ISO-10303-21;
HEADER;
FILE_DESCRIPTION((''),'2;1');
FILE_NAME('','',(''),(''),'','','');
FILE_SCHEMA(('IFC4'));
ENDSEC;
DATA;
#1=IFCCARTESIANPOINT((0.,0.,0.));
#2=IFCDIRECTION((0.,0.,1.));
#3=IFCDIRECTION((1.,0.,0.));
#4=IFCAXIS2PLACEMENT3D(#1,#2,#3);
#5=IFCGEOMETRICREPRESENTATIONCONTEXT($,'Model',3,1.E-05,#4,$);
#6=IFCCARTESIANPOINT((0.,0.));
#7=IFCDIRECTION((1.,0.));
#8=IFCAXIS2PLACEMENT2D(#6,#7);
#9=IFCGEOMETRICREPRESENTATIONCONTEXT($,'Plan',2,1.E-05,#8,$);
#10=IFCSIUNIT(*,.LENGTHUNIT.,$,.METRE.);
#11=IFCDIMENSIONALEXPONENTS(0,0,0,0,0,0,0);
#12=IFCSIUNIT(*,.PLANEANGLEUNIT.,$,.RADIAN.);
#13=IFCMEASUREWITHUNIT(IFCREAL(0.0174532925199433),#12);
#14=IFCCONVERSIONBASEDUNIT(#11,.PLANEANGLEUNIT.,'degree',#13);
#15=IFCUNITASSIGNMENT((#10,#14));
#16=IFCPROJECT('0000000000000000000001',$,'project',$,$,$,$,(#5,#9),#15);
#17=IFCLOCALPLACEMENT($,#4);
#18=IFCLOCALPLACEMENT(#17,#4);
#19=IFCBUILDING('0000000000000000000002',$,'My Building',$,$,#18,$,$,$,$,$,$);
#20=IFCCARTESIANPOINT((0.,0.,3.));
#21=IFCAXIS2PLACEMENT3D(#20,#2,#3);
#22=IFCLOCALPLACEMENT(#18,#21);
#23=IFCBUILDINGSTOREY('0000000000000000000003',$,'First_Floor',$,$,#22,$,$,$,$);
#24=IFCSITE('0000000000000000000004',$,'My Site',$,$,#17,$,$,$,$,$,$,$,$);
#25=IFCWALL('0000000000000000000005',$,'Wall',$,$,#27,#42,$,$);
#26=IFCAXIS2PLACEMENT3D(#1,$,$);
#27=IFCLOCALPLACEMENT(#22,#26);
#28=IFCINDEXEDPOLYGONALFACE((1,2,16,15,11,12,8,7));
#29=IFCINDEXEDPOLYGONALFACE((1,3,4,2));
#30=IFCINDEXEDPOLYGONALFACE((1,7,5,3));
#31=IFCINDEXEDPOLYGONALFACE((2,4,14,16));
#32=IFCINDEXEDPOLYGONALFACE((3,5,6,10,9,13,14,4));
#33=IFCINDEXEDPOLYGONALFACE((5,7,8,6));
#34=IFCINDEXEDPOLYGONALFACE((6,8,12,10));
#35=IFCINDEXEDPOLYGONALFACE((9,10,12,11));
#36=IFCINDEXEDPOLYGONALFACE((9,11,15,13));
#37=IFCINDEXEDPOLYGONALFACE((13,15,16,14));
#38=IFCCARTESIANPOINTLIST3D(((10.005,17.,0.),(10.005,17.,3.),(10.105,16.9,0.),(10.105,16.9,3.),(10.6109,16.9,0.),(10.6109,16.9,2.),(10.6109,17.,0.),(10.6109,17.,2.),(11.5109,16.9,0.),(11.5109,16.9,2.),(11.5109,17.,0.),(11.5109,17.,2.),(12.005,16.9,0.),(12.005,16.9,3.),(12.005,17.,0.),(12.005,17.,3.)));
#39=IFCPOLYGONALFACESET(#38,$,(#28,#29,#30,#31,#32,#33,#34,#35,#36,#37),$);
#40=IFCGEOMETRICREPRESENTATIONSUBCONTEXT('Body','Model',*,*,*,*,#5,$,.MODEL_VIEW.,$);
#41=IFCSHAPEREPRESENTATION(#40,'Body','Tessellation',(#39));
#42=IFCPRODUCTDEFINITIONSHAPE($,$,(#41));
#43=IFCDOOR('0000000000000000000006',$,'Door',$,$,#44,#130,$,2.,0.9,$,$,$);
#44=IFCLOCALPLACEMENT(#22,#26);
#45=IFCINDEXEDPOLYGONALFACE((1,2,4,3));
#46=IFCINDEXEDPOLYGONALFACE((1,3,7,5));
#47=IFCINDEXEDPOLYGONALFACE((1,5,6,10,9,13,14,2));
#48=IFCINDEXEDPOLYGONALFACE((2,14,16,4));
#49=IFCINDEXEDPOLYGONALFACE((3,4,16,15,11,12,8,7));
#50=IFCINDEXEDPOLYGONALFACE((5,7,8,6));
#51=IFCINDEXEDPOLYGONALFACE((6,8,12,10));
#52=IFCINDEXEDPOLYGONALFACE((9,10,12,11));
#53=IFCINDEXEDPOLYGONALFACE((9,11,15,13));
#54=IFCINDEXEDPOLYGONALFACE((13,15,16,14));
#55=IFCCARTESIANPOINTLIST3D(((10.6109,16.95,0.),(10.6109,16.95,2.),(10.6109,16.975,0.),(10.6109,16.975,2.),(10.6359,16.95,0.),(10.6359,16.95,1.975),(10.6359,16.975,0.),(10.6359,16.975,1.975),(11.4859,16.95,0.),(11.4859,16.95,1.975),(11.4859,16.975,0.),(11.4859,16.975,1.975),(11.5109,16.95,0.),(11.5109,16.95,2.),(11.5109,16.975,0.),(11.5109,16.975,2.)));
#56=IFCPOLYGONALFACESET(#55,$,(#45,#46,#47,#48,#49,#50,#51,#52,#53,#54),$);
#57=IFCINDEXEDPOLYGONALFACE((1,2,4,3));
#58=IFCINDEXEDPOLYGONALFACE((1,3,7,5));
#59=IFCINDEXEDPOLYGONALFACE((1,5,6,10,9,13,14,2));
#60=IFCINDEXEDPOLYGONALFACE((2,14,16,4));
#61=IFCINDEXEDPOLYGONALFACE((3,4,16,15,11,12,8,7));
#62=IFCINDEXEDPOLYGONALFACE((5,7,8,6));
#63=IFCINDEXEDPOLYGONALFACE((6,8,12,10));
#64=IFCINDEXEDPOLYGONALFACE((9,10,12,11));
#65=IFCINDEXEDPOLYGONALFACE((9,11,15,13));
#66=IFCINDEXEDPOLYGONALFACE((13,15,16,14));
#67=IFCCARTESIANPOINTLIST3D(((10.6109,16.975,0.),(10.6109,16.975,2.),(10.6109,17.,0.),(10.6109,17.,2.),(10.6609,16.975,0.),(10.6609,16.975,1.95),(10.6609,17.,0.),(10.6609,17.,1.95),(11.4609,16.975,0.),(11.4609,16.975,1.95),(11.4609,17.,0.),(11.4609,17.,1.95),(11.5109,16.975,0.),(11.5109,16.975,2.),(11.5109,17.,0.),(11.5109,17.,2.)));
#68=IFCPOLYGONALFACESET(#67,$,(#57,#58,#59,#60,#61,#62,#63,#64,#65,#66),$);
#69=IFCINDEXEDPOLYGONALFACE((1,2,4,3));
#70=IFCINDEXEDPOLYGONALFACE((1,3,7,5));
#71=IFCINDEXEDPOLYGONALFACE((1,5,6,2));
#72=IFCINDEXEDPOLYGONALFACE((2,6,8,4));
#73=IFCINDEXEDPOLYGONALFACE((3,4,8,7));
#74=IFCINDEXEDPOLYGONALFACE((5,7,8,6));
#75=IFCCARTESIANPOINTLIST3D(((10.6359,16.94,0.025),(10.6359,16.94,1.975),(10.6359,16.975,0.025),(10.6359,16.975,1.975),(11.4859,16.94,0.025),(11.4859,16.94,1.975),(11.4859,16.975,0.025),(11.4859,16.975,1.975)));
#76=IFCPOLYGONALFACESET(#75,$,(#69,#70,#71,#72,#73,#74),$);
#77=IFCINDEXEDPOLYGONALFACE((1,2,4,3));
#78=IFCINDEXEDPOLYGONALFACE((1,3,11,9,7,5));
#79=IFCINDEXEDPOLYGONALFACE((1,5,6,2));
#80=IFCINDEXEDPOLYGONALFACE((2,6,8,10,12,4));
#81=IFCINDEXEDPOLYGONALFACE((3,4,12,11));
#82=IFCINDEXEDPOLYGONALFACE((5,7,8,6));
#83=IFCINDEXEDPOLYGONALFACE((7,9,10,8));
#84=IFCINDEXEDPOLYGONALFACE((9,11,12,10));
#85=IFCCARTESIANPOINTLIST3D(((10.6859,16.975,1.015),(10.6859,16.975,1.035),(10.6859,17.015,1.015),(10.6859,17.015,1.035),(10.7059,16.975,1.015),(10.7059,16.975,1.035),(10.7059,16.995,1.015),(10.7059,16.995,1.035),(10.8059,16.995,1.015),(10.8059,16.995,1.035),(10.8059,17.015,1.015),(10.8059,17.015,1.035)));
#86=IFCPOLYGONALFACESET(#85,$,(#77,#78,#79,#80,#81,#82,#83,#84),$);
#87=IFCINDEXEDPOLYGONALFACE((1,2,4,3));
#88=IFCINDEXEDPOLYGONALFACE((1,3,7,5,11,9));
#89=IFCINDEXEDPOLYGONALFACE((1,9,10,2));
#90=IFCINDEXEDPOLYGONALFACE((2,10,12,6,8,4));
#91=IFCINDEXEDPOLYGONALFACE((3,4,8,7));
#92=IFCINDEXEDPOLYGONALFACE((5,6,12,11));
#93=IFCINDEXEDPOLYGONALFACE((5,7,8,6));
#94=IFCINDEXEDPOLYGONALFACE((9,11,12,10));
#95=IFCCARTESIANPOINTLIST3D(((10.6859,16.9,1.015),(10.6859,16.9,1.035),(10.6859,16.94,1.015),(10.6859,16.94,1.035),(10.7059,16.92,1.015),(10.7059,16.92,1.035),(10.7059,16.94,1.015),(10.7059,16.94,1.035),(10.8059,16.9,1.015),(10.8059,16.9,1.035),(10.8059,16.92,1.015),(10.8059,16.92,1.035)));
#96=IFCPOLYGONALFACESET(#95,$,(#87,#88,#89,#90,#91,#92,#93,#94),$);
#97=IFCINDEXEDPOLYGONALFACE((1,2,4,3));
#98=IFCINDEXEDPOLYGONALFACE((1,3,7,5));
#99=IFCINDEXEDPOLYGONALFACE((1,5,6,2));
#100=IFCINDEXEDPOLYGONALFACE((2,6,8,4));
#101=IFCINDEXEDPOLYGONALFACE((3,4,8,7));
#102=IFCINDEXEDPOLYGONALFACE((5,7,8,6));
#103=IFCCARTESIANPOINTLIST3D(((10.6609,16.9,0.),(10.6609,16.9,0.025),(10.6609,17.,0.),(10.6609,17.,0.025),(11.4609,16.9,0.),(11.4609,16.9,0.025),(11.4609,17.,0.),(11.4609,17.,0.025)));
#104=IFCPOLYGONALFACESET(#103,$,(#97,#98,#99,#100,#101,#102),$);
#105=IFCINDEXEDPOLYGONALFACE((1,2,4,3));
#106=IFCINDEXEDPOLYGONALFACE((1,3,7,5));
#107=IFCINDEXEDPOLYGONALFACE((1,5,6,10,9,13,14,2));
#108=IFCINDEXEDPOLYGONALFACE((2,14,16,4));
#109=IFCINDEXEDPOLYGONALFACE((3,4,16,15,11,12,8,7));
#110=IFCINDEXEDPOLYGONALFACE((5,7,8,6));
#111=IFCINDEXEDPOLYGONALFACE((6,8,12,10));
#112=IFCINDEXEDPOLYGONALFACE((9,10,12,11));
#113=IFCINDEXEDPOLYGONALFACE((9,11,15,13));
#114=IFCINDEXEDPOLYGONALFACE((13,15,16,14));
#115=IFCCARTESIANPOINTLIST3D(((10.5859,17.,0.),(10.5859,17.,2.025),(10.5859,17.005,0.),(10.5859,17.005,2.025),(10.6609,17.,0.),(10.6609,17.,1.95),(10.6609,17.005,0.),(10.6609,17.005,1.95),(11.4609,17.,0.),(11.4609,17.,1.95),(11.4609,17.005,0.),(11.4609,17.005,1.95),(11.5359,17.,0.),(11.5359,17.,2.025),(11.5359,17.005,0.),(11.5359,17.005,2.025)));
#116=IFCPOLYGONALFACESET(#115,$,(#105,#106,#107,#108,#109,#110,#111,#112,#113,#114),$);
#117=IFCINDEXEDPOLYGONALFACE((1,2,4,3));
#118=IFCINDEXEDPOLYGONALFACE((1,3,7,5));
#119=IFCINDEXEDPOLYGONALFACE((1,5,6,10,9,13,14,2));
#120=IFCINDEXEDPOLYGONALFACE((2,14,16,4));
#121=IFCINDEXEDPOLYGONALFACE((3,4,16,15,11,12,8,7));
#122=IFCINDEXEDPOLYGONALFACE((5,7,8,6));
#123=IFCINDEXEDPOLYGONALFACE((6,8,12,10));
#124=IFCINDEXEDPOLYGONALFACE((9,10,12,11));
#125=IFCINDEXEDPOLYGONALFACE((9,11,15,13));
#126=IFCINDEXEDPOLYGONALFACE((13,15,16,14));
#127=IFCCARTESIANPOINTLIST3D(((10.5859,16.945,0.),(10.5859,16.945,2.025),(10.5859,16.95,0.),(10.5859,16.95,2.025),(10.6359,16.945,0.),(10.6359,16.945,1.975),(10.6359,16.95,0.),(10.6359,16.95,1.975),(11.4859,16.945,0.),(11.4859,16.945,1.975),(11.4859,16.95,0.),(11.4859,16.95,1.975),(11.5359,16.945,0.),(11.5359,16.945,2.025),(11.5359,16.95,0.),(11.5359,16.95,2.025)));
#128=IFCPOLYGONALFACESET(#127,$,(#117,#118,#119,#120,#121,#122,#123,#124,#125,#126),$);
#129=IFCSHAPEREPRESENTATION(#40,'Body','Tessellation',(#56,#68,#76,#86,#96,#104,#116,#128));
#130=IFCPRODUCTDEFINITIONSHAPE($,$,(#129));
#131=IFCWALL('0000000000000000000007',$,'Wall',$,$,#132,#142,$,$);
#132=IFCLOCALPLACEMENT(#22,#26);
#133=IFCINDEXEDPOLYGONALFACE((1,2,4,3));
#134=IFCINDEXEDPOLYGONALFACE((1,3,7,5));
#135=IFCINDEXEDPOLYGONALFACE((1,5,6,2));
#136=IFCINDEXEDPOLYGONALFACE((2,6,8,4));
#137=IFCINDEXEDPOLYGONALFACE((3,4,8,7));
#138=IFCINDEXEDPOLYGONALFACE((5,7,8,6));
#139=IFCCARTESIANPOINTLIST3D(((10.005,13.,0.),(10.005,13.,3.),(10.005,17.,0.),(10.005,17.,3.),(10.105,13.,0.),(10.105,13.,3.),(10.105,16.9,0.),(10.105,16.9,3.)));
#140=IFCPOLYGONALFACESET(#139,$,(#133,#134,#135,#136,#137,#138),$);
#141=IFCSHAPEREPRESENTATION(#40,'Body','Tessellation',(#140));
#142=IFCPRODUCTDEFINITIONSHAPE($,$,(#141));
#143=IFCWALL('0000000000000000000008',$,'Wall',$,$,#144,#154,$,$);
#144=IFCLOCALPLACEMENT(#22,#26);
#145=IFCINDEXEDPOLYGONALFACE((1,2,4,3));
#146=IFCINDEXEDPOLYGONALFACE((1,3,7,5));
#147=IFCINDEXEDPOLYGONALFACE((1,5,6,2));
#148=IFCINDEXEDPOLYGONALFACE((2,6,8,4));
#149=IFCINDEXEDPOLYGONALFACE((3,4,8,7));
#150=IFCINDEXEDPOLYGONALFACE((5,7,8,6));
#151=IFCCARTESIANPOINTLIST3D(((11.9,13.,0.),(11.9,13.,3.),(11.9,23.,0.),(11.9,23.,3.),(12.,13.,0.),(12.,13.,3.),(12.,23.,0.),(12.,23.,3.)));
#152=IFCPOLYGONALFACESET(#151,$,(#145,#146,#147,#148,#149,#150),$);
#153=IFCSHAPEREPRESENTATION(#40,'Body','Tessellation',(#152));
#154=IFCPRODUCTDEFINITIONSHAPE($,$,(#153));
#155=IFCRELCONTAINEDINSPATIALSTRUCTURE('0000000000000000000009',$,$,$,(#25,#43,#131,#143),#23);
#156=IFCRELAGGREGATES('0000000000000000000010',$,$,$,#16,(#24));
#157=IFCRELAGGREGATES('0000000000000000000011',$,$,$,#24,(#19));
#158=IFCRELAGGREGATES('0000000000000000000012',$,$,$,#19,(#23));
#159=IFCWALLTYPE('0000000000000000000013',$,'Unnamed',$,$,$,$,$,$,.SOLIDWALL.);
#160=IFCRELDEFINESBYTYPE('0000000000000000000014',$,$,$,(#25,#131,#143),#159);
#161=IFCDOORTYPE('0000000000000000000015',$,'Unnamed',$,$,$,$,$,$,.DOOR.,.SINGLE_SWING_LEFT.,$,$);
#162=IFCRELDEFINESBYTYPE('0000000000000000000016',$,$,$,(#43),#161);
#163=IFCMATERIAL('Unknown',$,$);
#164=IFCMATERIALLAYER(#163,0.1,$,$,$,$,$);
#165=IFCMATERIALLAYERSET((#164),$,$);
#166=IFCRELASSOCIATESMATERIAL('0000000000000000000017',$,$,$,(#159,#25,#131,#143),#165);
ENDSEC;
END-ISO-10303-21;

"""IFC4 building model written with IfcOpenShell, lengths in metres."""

from ifc_helpers import new_model, entity, si_unit, converted_unit, frame, origin_with_axes, origin_2d_with_axis, place, context, subcontext, project, spatial, line, indexed_curve, outline, extrude, shape, source, transform, mapped, material, layer, layer_set, layer_usage, type_object, type_shapes, element, fill, save


model = new_model("IFC4")

# Units and contexts
model_context = context("Model", 3, precision=1e-05, world=origin_with_axes())
plan_context = context("Plan", 2, precision=1e-05, world=origin_2d_with_axis())
body_context_1 = subcontext(model_context, "Body", "Model", "MODEL_VIEW")
body_context_2 = subcontext(plan_context, "Body", "Plan", "PLAN_VIEW")
ifc_project = project(units=[si_unit("LENGTHUNIT", "METRE"), converted_unit("PLANEANGLEUNIT", "degree", entity("IfcReal", 0.0174532925199433), si_unit("PLANEANGLEUNIT", "RADIAN"), dimensions=[0, 0, 0, 0, 0, 0, 0])], contexts=[model_context, plan_context])

# Site, building, storey
site_placement = place(None, origin_with_axes())
site = spatial("IfcSite", under=ifc_project, at=site_placement, Name="My Site")
building_placement = place(site_placement, origin_with_axes())
building = spatial("IfcBuilding", under=site, at=building_placement, Name="My Building")
storey_placement = place(building_placement, frame((0.0, 0.0, 3.0), z_axis=(0.0, 0.0, 1.0), x_axis=(1.0, 0.0, 0.0)))
storey = spatial("IfcBuildingStorey", under=building, at=storey_placement, Name="First_Floor")

# Wall, opening, door
ifc_material = material(Name="Unknown")
ifc_layer = layer(ifc_material, 0.1)
ifc_layer_set = layer_set([ifc_layer])
ifc_layer_usage_1 = layer_usage(ifc_layer_set, "AXIS2", "POSITIVE", 0.0)
wall_type = type_object("IfcWallType", Name="Unnamed", PredefinedType="SOLIDWALL", material=ifc_layer_set)
wall_1_placement = place(storey_placement, frame((12.005, 17.0, 0.0), z_axis=(0.0, 0.0, 1.0), x_axis=(-1.0, 0.0, 0.0)))
wall_1 = element("IfcWall", 1, at=wall_1_placement, inside=storey, type_object=wall_type, material=ifc_layer_usage_1, Name="Wall", context=body_context_1, shape_type="SweptSolid", body=[
    extrude(outline(indexed_curve([(0.0, 0.0), (0.0, 0.1), (1.9, 0.1), (2.0, 0.0)], segments=[line(1, 2, 3, 4, 1)])), origin_with_axes(), (0.0, 0.0, 1.0), 3.0),
])
shared_shape_1 = source(origin_with_axes(), body_context_1, "Body", "SweptSolid", [
    extrude(outline(indexed_curve([(0.0, 0.0), (0.9, 0.0), (0.9, 2.0), (0.0, 2.0)], segments=[line(1, 2, 3, 4, 1)])), frame((0.0, -0.6, 0.0), z_axis=(0.0, -1.0, 0.0), x_axis=(1.0, 0.0, 0.0)), (0.0, 0.0, -1.0), 1.2),
])
opening_1_placement = place(wall_1_placement, frame((0.4941, 0.0, 0.0), z_axis=(0.0, 0.0, 1.0), x_axis=(1.0, 0.0, 0.0)))
opening_1 = element("IfcOpeningElement", 2, at=opening_1_placement, cuts=wall_1, PredefinedType="OPENING", context=body_context_1, shape_type="MappedRepresentation", body=[
    mapped(shared_shape_1, transform((0.0, 0.0, 0.0), x_axis=(1.0, 0.0, 0.0), y_axis=(0.0, 1.0, 0.0), z_axis=(0.0, 0.0, 1.0), scale=1.0)),
])
door_type = type_object("IfcDoorType", Name="Unnamed", OperationType="SINGLE_SWING_LEFT", PredefinedType="DOOR")
shared_shape_2 = source(origin_with_axes(), body_context_1, "Body", "SweptSolid", [
    extrude(outline(indexed_curve([(0.0, 0.0), (0.0, 2.0), (0.9, 2.0), (0.9, 0.0), (0.875, 0.0), (0.875, 1.975), (0.025, 1.975), (0.025, 0.0)], segments=[line(1, 2, 3, 4, 5, 6, 7, 8, 1)])), frame((0.0, 0.025, 0.0), z_axis=(0.0, -1.0, 0.0), x_axis=(1.0, 0.0, 0.0)), (0.0, 0.0, -1.0), 0.025),
    extrude(outline(indexed_curve([(0.0, 0.0), (0.0, 2.0), (0.9, 2.0), (0.9, 0.0), (0.85, 0.0), (0.85, 1.95), (0.05, 1.95), (0.05, 0.0)], segments=[line(1, 2, 3, 4, 5, 6, 7, 8, 1)])), frame((0.0, 0.0, 0.0), z_axis=(0.0, -1.0, 0.0), x_axis=(1.0, 0.0, 0.0)), (0.0, 0.0, -1.0), 0.025),
    extrude(outline(indexed_curve([(0.0, 0.0), (0.85, 0.0), (0.85, 0.035), (0.0, 0.035)], segments=[line(1, 2, 3, 4, 1)])), frame((0.025, 0.025, 0.025), z_axis=(0.0, 0.0, 1.0), x_axis=(1.0, 0.0, 0.0)), (0.0, 0.0, 1.0), 1.95),
    extrude(outline(indexed_curve([(0.0, 0.0), (0.0, -0.04), (-0.12, -0.04), (-0.12, -0.02), (-0.02, -0.02), (-0.02, 0.0)], segments=[line(1, 2, 3, 4, 5, 6, 1)])), frame((0.825, 0.025, 1.015), z_axis=(0.0, 0.0, 1.0), x_axis=(1.0, 0.0, 0.0)), (0.0, 0.0, 1.0), 0.02),
    extrude(outline(indexed_curve([(0.0, 0.0), (0.0, 0.04), (-0.12, 0.04), (-0.12, 0.02), (-0.02, 0.02), (-0.02, 0.0)], segments=[line(1, 2, 3, 4, 5, 6, 1)])), frame((0.825, 0.06, 1.015), z_axis=(0.0, 0.0, 1.0), x_axis=(1.0, 0.0, 0.0)), (0.0, 0.0, 1.0), 0.02),
    extrude(outline(indexed_curve([(0.0, 0.0), (0.8, 0.0), (0.8, 0.1), (0.0, 0.1)], segments=[line(1, 2, 3, 4, 1)])), frame((0.05, 0.0, 0.0), z_axis=(0.0, 0.0, 1.0), x_axis=(1.0, 0.0, 0.0)), (0.0, 0.0, 1.0), 0.025),
    extrude(outline(indexed_curve([(0.0, 0.0), (0.0, 2.025), (0.95, 2.025), (0.95, 0.0), (0.875, 0.0), (0.875, 1.95), (0.075, 1.95), (0.075, 0.0)], segments=[line(1, 2, 3, 4, 5, 6, 7, 8, 1)])), frame((-0.025, -0.005, 0.0), z_axis=(0.0, -1.0, 0.0), x_axis=(1.0, 0.0, 0.0)), (0.0, 0.0, -1.0), 0.005),
    extrude(outline(indexed_curve([(0.0, 0.0), (0.0, 2.025), (0.95, 2.025), (0.95, 0.0), (0.9, 0.0), (0.9, 1.975), (0.05, 1.975), (0.05, 0.0)], segments=[line(1, 2, 3, 4, 5, 6, 7, 8, 1)])), frame((-0.025, 0.05, 0.0), z_axis=(0.0, -1.0, 0.0), x_axis=(1.0, 0.0, 0.0)), (0.0, 0.0, -1.0), 0.005),
])
shared_shape_3 = source(origin_with_axes(), body_context_2, "Body", "Curve2D", [
    entity("IfcIndexedPolyCurve", entity("IfcCartesianPointList2D", [[0.0, 0.0], [0.0, 0.05], [0.025, 0.05], [0.025, 0.025], [0.05, 0.025], [0.05, 0.0]]), [entity("IfcLineIndex", [1, 2, 3, 4, 5, 6, 1])]),
    entity("IfcIndexedPolyCurve", entity("IfcCartesianPointList2D", [[0.9, 0.0], [0.9, 0.05], [0.875, 0.05], [0.875, 0.025], [0.85, 0.025], [0.85, 0.0]]), [entity("IfcLineIndex", [1, 2, 3, 4, 5, 6, 1])]),
    entity("IfcTrimmedCurve", entity("IfcEllipse", entity("IfcAxis2Placement2D", entity("IfcCartesianPoint", [0.06, 0.05]), entity("IfcDirection", [1.0, 0.0])), 0.815, 0.85), [entity("IfcCartesianPoint", [0.875, 0.05])], [entity("IfcCartesianPoint", [0.06, 0.9])], True, "CARTESIAN"),
    entity("IfcIndexedPolyCurve", entity("IfcCartesianPointList2D", [[0.025, 0.05], [0.06, 0.05], [0.06, 0.9], [0.025, 0.9]]), [entity("IfcLineIndex", [1, 2, 3, 4, 1])]),
])
type_shapes(door_type, [shared_shape_2, shared_shape_3])
door_1_placement = place(opening_1_placement, frame((0.0, 0.0, 0.0), z_axis=(0.0, 0.0, 1.0), x_axis=(1.0, 0.0, 0.0)))
door_1 = element("IfcDoor", 3, at=door_1_placement, inside=storey, type_object=door_type, Name="Door", OverallHeight=2.0, OverallWidth=0.9, shapes=[
    shape(body_context_1, "Body", "MappedRepresentation", [mapped(shared_shape_2, transform((0.0, 0.0, 0.0), x_axis=(1.0, 0.0, 0.0), y_axis=(0.0, 1.0, 0.0), z_axis=(0.0, 0.0, 1.0), scale=1.0))]),
    shape(body_context_2, "Body", "MappedRepresentation", [mapped(shared_shape_3, transform((0.0, 0.0, 0.0), x_axis=(1.0, 0.0, 0.0), y_axis=(0.0, 1.0, 0.0), z_axis=(0.0, 0.0, 1.0), scale=1.0))]),
])
fill(opening_1, door_1)

# Walls
ifc_layer_usage_2 = layer_usage(ifc_layer_set, "AXIS2", "POSITIVE", 0.0)
wall_2_placement = place(storey_placement, frame((10.005, 17.0, 0.0), z_axis=(0.0, 0.0, 1.0), x_axis=(0.0, -1.0, 0.0)))
element("IfcWall", 4, at=wall_2_placement, inside=storey, type_object=wall_type, material=ifc_layer_usage_2, Name="Wall", context=body_context_1, shape_type="SweptSolid", body=[
    extrude(outline(indexed_curve([(0.0, 0.0), (0.1, 0.1), (4.0, 0.1), (4.0, 0.0)], segments=[line(1, 2, 3, 4, 1)])), origin_with_axes(), (0.0, 0.0, 1.0), 3.0),
])
ifc_layer_usage_3 = layer_usage(ifc_layer_set, "AXIS2", "POSITIVE", 0.0)
wall_3_placement = place(storey_placement, frame((11.9, 23.0, 0.0), z_axis=(0.0, 0.0, 1.0), x_axis=(0.0, -1.0, 0.0)))
element("IfcWall", 5, at=wall_3_placement, inside=storey, type_object=wall_type, material=ifc_layer_usage_3, Name="Wall", context=body_context_1, shape_type="SweptSolid", body=[
    extrude(outline(indexed_curve([(0.0, 0.0), (0.0, 0.1), (10.0, 0.1), (10.0, 0.0)], segments=[line(1, 2, 3, 4, 1)])), origin_with_axes(), (0.0, 0.0, 1.0), 3.0),
])

save(model, "model.ifc")
